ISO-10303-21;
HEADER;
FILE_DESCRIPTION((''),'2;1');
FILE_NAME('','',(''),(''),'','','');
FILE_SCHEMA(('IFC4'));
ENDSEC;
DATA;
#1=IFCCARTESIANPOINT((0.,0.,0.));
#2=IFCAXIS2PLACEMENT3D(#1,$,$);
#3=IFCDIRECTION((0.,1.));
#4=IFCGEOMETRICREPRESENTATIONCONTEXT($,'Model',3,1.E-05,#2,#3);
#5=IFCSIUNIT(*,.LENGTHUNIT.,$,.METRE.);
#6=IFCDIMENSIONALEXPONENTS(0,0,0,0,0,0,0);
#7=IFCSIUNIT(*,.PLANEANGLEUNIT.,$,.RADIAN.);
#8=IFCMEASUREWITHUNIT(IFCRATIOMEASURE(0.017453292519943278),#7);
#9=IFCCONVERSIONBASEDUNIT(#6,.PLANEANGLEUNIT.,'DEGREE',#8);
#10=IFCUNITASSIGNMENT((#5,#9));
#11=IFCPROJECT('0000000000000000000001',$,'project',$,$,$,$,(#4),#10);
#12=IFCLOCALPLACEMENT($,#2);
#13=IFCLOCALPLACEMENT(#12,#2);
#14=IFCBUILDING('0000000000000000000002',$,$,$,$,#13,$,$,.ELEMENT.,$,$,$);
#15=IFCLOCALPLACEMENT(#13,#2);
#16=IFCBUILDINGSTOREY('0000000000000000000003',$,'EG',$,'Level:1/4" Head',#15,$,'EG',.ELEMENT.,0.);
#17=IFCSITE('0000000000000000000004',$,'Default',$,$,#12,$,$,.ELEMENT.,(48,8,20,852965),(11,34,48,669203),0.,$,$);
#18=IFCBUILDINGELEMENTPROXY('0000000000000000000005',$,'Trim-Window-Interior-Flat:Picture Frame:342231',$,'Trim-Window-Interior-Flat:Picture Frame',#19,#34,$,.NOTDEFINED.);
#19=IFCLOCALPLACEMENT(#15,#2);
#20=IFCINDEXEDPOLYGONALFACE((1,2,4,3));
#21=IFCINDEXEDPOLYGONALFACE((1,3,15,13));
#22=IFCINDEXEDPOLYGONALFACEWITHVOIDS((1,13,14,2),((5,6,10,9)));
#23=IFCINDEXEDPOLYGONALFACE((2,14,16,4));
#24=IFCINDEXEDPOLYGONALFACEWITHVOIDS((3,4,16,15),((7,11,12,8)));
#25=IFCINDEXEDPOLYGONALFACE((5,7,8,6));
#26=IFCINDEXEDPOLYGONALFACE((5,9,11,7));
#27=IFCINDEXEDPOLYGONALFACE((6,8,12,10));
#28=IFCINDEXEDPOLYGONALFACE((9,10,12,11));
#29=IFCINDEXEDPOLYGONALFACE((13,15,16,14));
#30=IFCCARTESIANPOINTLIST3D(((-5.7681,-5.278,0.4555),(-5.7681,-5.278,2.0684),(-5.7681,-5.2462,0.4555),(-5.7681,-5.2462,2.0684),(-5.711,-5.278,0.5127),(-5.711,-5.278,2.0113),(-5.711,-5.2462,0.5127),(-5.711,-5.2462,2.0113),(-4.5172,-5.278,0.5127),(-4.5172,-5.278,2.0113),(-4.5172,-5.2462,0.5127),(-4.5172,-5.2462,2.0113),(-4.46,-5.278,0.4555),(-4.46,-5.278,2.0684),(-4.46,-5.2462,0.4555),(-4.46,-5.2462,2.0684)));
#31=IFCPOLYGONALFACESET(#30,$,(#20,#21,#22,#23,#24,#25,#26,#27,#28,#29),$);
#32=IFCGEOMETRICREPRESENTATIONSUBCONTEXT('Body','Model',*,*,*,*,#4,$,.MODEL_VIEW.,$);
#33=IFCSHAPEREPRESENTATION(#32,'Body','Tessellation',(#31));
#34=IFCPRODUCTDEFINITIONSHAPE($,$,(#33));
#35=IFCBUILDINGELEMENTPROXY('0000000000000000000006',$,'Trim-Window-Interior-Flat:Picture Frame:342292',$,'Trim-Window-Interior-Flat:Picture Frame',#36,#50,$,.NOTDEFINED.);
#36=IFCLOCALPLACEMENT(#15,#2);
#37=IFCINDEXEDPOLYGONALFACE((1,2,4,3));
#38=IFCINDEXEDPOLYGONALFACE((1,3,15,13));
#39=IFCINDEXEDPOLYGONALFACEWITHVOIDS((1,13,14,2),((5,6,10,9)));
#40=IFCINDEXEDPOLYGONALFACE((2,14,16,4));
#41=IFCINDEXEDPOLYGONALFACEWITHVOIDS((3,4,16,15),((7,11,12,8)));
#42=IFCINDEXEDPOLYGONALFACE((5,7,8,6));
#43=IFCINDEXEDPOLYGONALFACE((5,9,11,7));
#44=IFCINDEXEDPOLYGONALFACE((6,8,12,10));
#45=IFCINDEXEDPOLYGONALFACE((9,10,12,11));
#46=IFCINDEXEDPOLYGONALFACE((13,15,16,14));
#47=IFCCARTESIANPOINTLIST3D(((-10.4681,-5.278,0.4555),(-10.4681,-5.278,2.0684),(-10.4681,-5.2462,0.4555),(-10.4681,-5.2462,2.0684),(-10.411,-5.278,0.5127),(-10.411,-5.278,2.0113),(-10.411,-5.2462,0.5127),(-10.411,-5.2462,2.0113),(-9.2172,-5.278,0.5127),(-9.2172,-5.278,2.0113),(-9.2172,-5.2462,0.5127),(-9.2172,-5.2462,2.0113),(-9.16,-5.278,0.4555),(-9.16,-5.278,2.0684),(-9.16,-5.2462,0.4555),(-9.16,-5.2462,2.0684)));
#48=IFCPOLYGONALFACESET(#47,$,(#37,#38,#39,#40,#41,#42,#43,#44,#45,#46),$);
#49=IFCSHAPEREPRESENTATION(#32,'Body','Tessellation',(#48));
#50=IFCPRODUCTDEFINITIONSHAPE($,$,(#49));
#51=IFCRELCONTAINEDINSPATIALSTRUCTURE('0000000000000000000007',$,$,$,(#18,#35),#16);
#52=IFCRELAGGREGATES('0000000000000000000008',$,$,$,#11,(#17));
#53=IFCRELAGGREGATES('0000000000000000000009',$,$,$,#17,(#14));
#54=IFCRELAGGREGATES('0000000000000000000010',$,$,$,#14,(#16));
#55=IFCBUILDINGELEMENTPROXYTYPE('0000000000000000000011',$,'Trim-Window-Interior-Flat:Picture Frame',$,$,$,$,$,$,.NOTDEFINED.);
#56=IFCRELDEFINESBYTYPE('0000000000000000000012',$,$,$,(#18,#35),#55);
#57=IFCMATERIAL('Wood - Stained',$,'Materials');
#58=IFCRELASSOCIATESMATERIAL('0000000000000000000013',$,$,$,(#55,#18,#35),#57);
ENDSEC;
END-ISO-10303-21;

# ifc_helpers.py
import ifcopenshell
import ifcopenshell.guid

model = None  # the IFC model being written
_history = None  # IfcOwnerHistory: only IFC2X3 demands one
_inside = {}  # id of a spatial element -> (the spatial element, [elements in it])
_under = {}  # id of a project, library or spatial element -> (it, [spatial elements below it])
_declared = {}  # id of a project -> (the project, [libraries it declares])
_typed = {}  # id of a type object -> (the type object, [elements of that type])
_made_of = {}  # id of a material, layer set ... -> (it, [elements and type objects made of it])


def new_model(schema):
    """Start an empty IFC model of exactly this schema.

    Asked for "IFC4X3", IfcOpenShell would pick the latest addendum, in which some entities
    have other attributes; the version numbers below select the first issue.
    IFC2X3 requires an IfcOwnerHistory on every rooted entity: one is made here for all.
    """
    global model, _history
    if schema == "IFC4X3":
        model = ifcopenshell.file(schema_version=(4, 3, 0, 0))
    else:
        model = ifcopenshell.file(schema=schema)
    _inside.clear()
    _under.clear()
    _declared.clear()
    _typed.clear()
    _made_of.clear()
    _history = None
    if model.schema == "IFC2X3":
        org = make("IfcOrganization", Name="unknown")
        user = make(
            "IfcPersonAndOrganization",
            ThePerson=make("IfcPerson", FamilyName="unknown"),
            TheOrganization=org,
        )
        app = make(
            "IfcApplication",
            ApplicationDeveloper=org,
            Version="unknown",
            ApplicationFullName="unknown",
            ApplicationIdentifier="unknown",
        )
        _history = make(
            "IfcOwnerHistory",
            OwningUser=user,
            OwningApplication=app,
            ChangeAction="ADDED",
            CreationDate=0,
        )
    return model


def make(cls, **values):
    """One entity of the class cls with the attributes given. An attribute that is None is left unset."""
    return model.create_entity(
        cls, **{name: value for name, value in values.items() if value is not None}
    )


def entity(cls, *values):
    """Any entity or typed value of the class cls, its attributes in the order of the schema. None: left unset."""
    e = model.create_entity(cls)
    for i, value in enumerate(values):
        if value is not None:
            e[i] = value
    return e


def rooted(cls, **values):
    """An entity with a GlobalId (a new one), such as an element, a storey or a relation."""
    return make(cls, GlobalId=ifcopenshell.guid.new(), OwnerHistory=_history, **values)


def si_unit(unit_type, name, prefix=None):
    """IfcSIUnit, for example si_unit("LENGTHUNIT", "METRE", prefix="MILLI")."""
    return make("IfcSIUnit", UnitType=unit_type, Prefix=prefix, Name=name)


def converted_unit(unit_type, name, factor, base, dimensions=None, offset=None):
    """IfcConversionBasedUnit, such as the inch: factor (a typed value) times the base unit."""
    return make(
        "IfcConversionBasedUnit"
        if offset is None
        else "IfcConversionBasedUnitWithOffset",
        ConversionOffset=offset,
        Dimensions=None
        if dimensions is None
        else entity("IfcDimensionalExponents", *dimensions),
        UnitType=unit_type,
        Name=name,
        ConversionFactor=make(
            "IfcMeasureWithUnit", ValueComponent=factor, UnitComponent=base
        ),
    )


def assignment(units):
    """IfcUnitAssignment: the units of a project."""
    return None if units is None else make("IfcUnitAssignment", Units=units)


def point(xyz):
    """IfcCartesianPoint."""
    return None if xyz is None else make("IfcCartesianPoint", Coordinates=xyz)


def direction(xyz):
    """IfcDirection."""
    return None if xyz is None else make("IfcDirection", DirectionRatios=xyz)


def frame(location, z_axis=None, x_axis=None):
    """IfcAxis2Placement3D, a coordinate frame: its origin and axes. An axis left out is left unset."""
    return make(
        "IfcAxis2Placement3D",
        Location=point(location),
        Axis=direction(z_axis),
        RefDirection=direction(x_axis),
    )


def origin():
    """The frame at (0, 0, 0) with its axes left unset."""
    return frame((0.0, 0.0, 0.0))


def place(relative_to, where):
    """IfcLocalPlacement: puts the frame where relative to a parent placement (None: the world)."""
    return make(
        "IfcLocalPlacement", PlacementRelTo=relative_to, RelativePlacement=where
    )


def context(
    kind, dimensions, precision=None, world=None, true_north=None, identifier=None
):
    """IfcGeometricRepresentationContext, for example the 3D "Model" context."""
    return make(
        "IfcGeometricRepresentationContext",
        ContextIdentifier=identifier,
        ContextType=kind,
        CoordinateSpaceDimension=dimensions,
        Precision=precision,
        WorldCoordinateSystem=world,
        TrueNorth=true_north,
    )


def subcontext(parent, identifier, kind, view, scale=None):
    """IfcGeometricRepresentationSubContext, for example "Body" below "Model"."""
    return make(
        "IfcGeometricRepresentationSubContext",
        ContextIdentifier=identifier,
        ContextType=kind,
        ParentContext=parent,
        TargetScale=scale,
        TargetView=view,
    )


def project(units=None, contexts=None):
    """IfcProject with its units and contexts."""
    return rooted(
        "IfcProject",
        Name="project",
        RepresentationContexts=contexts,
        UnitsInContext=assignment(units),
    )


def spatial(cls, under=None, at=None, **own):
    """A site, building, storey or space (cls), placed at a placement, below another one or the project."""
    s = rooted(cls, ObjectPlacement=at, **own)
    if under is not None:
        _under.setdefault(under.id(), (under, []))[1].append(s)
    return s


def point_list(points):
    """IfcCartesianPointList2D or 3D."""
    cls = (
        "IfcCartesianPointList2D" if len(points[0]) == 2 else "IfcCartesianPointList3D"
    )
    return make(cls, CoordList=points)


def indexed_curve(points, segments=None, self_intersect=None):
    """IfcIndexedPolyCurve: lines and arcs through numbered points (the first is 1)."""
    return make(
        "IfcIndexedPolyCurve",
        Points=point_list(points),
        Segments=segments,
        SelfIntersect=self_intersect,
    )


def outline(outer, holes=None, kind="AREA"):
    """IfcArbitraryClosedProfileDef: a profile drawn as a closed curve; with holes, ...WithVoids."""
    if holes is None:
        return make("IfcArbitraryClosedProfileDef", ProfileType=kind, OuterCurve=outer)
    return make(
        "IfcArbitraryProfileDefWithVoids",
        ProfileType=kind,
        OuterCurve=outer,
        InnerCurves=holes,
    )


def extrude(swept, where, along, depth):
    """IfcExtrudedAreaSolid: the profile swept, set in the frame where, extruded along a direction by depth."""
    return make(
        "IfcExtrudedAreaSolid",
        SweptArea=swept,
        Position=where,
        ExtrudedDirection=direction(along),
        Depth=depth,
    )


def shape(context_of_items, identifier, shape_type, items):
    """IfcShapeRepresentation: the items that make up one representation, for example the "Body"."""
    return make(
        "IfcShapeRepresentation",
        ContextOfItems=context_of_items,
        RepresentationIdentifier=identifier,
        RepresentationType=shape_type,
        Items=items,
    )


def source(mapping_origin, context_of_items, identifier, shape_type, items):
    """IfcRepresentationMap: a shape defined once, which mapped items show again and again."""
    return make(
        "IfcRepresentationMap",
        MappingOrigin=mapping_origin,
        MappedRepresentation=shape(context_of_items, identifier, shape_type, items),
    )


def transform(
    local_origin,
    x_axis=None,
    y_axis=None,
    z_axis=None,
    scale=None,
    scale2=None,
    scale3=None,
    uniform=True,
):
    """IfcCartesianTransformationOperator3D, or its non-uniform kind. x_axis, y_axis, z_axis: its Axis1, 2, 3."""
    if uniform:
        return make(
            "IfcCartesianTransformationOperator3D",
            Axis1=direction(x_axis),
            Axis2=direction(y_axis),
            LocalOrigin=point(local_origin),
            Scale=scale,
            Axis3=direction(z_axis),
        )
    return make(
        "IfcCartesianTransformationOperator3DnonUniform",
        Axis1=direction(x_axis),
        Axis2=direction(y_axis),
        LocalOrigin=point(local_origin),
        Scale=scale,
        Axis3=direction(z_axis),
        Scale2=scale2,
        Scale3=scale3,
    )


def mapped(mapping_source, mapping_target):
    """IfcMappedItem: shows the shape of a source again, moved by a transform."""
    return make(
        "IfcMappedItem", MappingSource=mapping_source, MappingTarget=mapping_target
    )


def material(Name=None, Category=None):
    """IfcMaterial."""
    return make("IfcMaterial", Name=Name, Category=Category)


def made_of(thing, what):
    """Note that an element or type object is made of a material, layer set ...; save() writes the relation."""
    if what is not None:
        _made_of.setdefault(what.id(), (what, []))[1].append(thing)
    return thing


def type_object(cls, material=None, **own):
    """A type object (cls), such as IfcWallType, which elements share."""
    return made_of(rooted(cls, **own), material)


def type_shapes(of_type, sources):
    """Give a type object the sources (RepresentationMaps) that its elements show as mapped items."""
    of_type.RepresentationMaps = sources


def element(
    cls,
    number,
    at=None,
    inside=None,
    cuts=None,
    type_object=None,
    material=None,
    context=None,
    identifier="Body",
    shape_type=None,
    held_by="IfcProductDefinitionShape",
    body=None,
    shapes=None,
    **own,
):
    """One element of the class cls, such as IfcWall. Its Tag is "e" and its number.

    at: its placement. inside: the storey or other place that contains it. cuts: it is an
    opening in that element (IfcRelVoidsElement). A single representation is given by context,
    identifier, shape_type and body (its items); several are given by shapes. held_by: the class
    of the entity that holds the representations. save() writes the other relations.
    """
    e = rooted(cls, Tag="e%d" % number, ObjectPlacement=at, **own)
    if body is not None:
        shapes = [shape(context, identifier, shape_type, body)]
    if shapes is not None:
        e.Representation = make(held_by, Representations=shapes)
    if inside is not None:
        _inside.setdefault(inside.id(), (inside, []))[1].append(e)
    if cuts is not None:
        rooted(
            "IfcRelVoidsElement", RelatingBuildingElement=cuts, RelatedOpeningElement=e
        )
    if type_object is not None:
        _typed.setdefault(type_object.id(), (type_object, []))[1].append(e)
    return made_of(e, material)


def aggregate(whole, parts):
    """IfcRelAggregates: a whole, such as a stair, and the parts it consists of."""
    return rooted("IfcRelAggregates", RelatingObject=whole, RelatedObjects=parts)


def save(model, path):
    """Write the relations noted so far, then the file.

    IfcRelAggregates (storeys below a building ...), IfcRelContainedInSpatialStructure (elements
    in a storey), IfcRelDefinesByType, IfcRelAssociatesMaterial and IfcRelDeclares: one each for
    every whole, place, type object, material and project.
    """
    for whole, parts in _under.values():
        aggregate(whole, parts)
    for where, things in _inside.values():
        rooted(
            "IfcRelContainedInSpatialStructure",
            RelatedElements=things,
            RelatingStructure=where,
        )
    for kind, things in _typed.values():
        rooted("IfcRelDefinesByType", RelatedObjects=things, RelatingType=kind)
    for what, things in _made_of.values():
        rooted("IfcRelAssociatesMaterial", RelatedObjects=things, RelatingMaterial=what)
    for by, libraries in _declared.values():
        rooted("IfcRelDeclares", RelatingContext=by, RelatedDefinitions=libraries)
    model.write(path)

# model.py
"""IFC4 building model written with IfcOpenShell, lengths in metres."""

from ifc_helpers import new_model, entity, si_unit, converted_unit, direction, frame, origin, place, context, subcontext, project, spatial, indexed_curve, outline, extrude, source, transform, mapped, material, type_object, type_shapes, element, save


model = new_model("IFC4")

# Units and contexts
model_context = context("Model", 3, precision=1e-05, world=origin(), true_north=direction((0.0, 1.0)))
body_context = subcontext(model_context, "Body", "Model", "MODEL_VIEW")
ifc_project = project(units=[si_unit("LENGTHUNIT", "METRE"), converted_unit("PLANEANGLEUNIT", "DEGREE", entity("IfcRatioMeasure", 0.017453292519943278), si_unit("PLANEANGLEUNIT", "RADIAN"), dimensions=[0, 0, 0, 0, 0, 0, 0])], contexts=[model_context])

# Site, building, storey
site_placement = place(None, origin())
site = spatial("IfcSite", under=ifc_project, at=site_placement, Name="Default", CompositionType="ELEMENT", RefLatitude=(48, 8, 20, 852965), RefLongitude=(11, 34, 48, 669203), RefElevation=0.0)
building_placement = place(site_placement, origin())
building = spatial("IfcBuilding", under=site, at=building_placement, CompositionType="ELEMENT")
storey_placement = place(building_placement, origin())
storey = spatial("IfcBuildingStorey", under=building, at=storey_placement, Name="EG", ObjectType="Level:1/4\" Head", LongName="EG", CompositionType="ELEMENT", Elevation=0.0)

# Building element proxies
ifc_material_1 = material(Name="Wood - Stained", Category="Materials")
building_element_proxy_type_1 = type_object("IfcBuildingElementProxyType", Name="Trim-Window-Interior-Flat:Picture Frame", PredefinedType="NOTDEFINED", material=ifc_material_1)
shared_shape_1 = source(origin(), body_context, "Body", "SweptSolid", [
    extrude(outline(indexed_curve([(-0.654, -0.8064), (0.654, -0.8064), (0.654, 0.8064), (-0.654, 0.8064), (-0.654, -0.8064)], self_intersect=False), holes=[indexed_curve([(-0.5969, -0.7493), (-0.5969, 0.7493), (0.5969, 0.7493), (0.5969, -0.7493), (-0.5969, -0.7493)], self_intersect=False)]), frame((0.0, -0.762, 0.0), z_axis=(0.0, 0.0, 1.0), x_axis=(-1.0, 0.0, 0.0)), (0.0, 0.0, 1.0), 0.0317),
])
type_shapes(building_element_proxy_type_1, [shared_shape_1])
for number, where, z_axis, x_axis, name in (
    (1, (-5.1141, -5.278, 2.024), (0.0, 1.0, 0.0), (-1.0, 0.0, 0.0), "Trim-Window-Interior-Flat:Picture Frame:342231"),
    (2, (-9.8141, -5.278, 2.024), (0.0, 1.0, 0.0), (-1.0, 0.0, 0.0), "Trim-Window-Interior-Flat:Picture Frame:342292"),
):
    element("IfcBuildingElementProxy", number, at=place(storey_placement, frame(where, z_axis=z_axis, x_axis=x_axis)), inside=storey, type_object=building_element_proxy_type_1, material=ifc_material_1, Name=name, ObjectType="Trim-Window-Interior-Flat:Picture Frame", PredefinedType="NOTDEFINED", context=body_context, shape_type="MappedRepresentation", body=[
        mapped(shared_shape_1, transform((0.0, 0.0, 0.0), scale=1.0)),
    ])

save(model, "model.ifc")
